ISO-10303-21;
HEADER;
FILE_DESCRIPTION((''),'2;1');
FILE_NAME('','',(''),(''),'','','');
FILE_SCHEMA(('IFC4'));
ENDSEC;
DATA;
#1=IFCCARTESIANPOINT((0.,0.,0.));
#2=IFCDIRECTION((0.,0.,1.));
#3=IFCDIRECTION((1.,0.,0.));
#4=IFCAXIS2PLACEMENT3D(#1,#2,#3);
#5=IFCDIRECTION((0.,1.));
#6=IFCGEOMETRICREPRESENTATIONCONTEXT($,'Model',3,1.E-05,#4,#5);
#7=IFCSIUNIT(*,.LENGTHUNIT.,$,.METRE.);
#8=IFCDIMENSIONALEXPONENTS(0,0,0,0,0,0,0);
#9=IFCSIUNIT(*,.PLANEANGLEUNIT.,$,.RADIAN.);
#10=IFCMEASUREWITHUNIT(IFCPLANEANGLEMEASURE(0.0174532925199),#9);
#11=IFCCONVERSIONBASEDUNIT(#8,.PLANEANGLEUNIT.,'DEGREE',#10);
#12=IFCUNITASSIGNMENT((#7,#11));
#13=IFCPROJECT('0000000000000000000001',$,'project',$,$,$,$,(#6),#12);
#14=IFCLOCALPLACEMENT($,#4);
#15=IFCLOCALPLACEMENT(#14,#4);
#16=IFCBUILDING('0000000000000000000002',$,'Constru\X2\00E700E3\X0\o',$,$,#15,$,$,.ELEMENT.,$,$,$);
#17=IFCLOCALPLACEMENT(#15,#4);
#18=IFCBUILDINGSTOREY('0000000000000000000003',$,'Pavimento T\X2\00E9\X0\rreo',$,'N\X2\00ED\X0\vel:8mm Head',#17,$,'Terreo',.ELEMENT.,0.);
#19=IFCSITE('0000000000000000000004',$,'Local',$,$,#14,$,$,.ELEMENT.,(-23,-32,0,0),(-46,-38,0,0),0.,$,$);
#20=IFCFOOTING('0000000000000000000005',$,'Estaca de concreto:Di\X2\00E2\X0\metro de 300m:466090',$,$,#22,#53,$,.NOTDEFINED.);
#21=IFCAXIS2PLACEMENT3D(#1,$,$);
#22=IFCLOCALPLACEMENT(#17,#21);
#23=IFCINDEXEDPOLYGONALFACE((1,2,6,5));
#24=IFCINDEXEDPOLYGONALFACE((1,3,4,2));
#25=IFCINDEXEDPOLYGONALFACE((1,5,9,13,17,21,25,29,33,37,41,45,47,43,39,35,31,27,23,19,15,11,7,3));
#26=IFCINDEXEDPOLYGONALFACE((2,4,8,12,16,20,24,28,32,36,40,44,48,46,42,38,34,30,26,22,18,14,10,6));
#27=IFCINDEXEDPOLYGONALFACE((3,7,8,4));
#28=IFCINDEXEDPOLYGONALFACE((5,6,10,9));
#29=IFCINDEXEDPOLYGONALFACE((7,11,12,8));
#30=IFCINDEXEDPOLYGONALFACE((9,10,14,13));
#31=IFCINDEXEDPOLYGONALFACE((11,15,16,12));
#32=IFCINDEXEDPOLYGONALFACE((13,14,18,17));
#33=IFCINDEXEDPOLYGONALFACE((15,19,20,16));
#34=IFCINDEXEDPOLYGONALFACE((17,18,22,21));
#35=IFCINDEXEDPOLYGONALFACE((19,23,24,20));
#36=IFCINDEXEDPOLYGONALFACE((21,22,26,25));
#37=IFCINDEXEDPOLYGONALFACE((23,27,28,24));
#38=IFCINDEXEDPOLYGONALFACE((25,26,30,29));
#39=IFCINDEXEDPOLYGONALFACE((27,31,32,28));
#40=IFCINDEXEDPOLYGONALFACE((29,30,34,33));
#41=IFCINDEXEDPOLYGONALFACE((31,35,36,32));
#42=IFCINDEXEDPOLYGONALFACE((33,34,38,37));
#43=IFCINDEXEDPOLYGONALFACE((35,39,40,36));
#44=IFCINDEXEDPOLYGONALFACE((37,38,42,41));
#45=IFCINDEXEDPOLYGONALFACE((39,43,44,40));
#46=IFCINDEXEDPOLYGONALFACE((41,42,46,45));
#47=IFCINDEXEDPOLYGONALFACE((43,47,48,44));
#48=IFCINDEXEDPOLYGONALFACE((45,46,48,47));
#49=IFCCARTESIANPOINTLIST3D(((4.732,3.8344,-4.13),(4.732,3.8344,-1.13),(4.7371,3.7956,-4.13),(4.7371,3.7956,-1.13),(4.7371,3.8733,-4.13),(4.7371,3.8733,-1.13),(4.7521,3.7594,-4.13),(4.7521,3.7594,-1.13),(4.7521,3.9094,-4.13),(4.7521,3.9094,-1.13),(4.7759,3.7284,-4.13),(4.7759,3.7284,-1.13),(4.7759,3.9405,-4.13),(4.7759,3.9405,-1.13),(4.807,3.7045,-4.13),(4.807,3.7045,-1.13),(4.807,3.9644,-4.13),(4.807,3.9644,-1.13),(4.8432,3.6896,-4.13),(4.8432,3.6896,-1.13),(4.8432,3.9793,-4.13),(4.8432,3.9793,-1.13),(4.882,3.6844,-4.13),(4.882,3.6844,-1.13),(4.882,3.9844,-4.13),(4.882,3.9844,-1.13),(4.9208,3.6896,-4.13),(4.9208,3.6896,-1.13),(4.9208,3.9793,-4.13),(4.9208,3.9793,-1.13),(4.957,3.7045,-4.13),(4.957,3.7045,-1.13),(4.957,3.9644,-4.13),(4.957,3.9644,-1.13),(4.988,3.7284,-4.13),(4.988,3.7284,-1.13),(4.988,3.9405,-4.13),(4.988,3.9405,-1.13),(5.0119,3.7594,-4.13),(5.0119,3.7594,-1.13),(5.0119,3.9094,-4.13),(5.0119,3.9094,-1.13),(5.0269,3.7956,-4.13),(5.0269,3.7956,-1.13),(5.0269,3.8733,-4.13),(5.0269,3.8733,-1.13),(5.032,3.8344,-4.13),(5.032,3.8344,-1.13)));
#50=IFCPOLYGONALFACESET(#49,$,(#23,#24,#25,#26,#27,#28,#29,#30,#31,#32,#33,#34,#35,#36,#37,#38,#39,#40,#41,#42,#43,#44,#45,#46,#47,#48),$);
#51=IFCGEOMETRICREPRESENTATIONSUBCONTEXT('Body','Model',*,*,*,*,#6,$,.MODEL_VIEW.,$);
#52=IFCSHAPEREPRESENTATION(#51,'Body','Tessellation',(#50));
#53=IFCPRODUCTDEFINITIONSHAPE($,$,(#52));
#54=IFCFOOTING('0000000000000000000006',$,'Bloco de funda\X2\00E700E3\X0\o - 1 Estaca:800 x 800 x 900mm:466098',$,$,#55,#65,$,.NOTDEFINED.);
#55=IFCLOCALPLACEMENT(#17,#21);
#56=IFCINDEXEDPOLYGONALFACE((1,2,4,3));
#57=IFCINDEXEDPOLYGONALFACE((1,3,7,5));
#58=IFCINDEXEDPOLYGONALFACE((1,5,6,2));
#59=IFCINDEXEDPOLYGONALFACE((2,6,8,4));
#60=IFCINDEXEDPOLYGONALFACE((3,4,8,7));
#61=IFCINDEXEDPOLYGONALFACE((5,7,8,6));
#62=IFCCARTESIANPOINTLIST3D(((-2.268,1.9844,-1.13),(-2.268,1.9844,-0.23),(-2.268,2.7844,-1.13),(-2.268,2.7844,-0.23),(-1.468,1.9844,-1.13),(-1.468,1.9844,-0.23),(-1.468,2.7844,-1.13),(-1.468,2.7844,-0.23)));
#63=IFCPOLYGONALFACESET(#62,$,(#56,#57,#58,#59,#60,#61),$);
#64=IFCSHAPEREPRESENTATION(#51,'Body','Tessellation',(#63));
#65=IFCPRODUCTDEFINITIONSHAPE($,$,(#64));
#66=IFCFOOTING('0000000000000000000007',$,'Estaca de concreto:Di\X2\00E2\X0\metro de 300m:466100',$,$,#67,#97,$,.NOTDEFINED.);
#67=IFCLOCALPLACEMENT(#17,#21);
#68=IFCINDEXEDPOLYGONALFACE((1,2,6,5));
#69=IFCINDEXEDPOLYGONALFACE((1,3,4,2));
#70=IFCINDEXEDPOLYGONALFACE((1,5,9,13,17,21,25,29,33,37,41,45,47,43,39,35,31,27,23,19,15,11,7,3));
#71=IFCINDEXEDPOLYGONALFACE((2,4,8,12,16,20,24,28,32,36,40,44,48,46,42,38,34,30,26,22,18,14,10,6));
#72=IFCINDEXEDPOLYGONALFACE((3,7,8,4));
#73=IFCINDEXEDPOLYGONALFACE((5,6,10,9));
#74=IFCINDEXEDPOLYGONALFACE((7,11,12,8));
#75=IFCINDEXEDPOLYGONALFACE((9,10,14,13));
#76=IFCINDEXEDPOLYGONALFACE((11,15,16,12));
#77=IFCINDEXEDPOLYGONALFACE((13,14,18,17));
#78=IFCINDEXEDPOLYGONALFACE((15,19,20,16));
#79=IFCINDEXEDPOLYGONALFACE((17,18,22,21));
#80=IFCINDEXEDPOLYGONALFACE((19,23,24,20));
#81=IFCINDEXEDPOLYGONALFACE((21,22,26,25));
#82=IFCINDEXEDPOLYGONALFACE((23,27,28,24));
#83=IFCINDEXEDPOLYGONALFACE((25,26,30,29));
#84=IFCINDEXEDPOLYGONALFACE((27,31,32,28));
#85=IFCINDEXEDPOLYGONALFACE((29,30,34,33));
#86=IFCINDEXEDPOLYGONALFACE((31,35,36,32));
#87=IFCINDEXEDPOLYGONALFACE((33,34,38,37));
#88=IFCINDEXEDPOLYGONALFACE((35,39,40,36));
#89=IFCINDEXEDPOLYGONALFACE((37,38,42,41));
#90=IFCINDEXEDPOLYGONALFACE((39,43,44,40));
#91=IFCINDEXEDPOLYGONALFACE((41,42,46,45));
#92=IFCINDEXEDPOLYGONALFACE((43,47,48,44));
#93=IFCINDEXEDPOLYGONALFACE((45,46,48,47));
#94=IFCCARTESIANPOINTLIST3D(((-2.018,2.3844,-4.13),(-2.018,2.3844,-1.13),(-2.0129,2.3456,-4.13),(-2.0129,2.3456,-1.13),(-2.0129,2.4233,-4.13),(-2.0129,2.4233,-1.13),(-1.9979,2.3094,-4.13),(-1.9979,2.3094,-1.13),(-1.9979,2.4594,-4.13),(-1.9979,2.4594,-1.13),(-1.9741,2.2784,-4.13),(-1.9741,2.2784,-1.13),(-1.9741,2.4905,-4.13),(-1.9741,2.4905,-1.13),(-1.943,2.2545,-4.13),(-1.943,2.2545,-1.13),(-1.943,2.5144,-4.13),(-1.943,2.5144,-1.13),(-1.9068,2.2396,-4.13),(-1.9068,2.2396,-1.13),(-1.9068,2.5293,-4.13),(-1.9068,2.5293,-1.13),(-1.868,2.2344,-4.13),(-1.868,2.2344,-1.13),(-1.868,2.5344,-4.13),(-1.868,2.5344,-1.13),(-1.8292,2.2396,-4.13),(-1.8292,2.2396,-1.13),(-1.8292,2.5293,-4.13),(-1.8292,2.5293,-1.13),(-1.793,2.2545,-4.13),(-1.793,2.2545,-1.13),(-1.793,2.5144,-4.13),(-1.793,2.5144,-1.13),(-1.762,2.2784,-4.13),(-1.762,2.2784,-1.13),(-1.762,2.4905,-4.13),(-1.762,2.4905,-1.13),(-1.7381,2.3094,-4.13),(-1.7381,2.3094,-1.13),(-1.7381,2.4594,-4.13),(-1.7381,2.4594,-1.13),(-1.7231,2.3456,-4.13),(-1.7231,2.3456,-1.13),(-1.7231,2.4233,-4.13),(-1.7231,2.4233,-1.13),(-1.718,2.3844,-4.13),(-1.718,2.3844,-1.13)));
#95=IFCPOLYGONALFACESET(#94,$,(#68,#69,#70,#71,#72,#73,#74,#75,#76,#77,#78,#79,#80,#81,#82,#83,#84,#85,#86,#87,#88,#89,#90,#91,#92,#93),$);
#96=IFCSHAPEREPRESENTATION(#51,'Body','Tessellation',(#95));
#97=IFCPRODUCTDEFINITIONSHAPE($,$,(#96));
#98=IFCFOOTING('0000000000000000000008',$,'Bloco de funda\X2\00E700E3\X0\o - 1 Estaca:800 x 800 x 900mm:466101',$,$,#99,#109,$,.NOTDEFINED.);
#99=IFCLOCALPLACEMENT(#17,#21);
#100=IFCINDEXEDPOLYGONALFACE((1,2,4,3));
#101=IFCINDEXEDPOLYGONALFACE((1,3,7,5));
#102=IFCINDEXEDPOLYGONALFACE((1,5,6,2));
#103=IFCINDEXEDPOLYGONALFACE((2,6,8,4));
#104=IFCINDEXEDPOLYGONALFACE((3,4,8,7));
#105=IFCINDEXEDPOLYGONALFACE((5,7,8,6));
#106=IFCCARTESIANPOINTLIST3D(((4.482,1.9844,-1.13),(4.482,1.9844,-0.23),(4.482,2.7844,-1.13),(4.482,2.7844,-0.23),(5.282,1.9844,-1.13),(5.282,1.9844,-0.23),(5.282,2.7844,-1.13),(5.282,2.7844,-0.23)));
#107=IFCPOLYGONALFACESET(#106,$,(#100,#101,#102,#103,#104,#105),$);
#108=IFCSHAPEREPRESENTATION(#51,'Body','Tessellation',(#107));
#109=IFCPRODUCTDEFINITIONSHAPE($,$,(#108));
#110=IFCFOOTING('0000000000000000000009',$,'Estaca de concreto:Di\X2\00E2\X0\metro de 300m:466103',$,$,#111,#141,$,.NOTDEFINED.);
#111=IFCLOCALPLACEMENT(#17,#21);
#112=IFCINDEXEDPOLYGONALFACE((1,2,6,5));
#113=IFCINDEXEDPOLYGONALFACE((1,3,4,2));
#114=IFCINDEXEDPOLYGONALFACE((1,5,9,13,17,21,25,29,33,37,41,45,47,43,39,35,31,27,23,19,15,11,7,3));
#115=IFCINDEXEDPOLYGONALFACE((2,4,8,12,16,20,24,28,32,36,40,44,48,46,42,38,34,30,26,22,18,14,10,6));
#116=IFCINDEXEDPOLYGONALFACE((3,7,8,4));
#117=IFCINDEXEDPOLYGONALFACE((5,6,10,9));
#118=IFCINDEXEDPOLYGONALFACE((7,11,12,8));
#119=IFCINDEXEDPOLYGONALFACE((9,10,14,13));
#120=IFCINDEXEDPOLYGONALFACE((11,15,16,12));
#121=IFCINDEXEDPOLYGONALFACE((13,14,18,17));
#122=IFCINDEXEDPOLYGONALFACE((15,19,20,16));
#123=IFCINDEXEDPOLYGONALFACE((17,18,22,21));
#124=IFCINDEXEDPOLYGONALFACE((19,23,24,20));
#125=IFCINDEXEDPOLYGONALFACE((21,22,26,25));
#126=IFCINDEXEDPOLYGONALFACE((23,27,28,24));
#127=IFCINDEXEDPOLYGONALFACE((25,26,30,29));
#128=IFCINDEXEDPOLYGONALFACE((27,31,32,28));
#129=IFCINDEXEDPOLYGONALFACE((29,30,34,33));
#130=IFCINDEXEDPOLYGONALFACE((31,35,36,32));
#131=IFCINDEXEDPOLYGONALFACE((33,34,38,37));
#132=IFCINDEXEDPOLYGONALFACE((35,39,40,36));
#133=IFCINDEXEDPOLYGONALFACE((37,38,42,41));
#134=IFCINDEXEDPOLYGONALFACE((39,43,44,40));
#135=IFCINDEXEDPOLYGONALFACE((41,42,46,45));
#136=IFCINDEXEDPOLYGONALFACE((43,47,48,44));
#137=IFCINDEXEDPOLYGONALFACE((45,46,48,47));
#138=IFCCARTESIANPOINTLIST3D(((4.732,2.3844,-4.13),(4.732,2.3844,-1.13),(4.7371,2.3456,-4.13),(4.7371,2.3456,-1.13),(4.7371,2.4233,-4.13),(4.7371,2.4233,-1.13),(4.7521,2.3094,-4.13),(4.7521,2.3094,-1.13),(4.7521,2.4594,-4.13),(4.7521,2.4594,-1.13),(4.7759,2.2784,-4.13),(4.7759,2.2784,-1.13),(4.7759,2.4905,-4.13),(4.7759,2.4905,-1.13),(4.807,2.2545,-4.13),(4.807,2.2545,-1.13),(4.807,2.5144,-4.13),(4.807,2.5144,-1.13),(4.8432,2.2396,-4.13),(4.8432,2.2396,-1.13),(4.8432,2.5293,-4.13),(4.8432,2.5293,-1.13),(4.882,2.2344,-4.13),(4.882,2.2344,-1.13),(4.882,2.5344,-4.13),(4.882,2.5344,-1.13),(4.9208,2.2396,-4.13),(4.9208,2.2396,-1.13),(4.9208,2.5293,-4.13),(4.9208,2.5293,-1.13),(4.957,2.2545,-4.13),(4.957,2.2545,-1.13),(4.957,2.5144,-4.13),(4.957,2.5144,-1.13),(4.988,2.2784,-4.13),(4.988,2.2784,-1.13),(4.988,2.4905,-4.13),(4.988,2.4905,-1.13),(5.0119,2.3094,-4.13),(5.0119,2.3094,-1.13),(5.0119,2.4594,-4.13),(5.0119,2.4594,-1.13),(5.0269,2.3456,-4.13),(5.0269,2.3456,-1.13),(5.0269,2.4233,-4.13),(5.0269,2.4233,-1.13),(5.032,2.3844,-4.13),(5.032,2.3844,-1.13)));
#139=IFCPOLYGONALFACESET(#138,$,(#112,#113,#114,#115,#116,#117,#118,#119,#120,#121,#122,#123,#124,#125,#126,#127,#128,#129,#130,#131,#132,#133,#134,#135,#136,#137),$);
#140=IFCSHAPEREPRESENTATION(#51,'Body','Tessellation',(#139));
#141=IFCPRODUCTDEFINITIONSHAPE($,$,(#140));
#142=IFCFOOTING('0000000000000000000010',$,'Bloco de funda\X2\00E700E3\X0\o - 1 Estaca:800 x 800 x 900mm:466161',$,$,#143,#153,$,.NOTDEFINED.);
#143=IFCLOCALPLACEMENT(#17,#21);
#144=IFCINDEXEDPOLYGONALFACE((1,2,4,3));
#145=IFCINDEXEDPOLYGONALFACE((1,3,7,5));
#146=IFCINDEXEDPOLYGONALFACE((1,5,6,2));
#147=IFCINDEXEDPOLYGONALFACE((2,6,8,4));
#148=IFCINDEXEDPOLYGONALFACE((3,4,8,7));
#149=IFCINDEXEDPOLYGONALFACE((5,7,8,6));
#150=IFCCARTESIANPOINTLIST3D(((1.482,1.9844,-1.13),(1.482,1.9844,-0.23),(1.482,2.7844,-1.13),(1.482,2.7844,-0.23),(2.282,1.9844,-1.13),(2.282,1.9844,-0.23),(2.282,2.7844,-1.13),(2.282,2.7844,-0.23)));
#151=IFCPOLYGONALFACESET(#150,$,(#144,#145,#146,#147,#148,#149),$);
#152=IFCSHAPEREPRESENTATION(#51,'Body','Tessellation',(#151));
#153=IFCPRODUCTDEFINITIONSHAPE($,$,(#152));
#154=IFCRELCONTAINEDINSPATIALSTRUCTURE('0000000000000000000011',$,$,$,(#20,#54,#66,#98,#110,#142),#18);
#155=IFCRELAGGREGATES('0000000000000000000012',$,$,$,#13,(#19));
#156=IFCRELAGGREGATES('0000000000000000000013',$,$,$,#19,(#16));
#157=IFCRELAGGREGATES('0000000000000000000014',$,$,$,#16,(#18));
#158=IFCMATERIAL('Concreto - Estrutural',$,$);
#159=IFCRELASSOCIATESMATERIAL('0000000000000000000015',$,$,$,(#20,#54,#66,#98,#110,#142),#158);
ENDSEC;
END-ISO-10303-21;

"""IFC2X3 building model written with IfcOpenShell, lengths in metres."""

from ifc_helpers import new_model, entity, si_unit, converted_unit, point, direction, frame, frame_2d, origin_with_axes, place, context, subcontext, project, spatial, polyline, circle_curve, parameter, trimmed, segment, composite_curve, outline, extrude, material, element, save


model = new_model("IFC2X3")

# Units and contexts
model_context = context("Model", 3, precision=1e-05, world=origin_with_axes(), true_north=direction((0.0, 1.0)))
body_context = subcontext(model_context, "Body", "Model", "MODEL_VIEW")
ifc_project = project(units=[si_unit("LENGTHUNIT", "METRE"), converted_unit("PLANEANGLEUNIT", "DEGREE", entity("IfcPlaneAngleMeasure", 0.0174532925199), si_unit("PLANEANGLEUNIT", "RADIAN"), dimensions=[0, 0, 0, 0, 0, 0, 0])], contexts=[model_context])

# Site, building, storey
site_placement = place(None, origin_with_axes())
site = spatial("IfcSite", under=ifc_project, at=site_placement, Name="Local", CompositionType="ELEMENT", RefLatitude=(-23, -32, 0, 0), RefLongitude=(-46, -38, 0, 0), RefElevation=0.0)
building_placement = place(site_placement, origin_with_axes())
building = spatial("IfcBuilding", under=site, at=building_placement, Name="Construção", CompositionType="ELEMENT")
storey_placement = place(building_placement, origin_with_axes())
storey = spatial("IfcBuildingStorey", under=building, at=storey_placement, Name="Pavimento Térreo", ObjectType="Nível:8mm Head", LongName="Terreo", CompositionType="ELEMENT", Elevation=0.0)

# Footings
ifc_material = material(Name="Concreto - Estrutural")
footing_1_placement = place(storey_placement, frame((5.032, 3.8344, -1.13), z_axis=(0.0, 0.0, 1.0), x_axis=(1.0, 0.0, 0.0)))
element("IfcFooting", 1, at=footing_1_placement, inside=storey, material=ifc_material, Name="Estaca de concreto:Diâmetro de 300m:466090", PredefinedType="NOTDEFINED", context=body_context, shape_type="SweptSolid", body=[
    extrude(outline(composite_curve([segment(trimmed(circle_curve(frame_2d((-0.15, 0.0), x_axis=(1.0, 0.0)), 0.15), [point((0.0, 0.0)), parameter(0.0)], [point((-0.15, 0.15)), parameter(90.0)], True, "CARTESIAN"), True, "CONTINUOUS"), segment(trimmed(circle_curve(frame_2d((-0.15, 0.0), x_axis=(0.0, 1.0)), 0.15), [point((-0.15, 0.15)), parameter(0.0)], [point((-0.3, 0.0)), parameter(90.0)], True, "CARTESIAN"), True, "CONTINUOUS"), segment(trimmed(circle_curve(frame_2d((-0.15, 0.0), x_axis=(-1.0, 0.0)), 0.15), [point((-0.3, 0.0)), parameter(0.0)], [point((-0.15, -0.15)), parameter(90.0)], True, "CARTESIAN"), True, "CONTINUOUS"), segment(trimmed(circle_curve(frame_2d((-0.15, 0.0), x_axis=(0.0, -1.0)), 0.15), [point((-0.15, -0.15)), parameter(0.0)], [point((0.0, 0.0)), parameter(90.0)], True, "CARTESIAN"), True, "CONTINUOUS")], self_intersect=False)), frame((0.0, 0.0, -3.0), z_axis=(0.0, 0.0, 1.0), x_axis=(1.0, 0.0, 0.0)), (0.0, 0.0, 1.0), 3.0),
])
footing_2_placement = place(storey_placement, frame((-2.268, 2.7844, -0.23), z_axis=(0.0, 0.0, 1.0), x_axis=(1.0, 0.0, 0.0)))
element("IfcFooting", 2, at=footing_2_placement, inside=storey, material=ifc_material, Name="Bloco de fundação - 1 Estaca:800 x 800 x 900mm:466098", PredefinedType="NOTDEFINED", context=body_context, shape_type="SweptSolid", body=[
    extrude(outline(polyline([(0.0, 0.0), (0.0, -0.8), (0.8, -0.8), (0.8, 0.0), (0.0, 0.0)])), frame((0.0, 0.0, -0.9), z_axis=(0.0, 0.0, 1.0), x_axis=(1.0, 0.0, 0.0)), (0.0, 0.0, 1.0), 0.9),
])
footing_3_placement = place(storey_placement, frame((-1.718, 2.3844, -1.13), z_axis=(0.0, 0.0, 1.0), x_axis=(1.0, 0.0, 0.0)))
element("IfcFooting", 3, at=footing_3_placement, inside=storey, material=ifc_material, Name="Estaca de concreto:Diâmetro de 300m:466100", PredefinedType="NOTDEFINED", context=body_context, shape_type="SweptSolid", body=[
    extrude(outline(composite_curve([segment(trimmed(circle_curve(frame_2d((-0.15, 0.0), x_axis=(1.0, 0.0)), 0.15), [point((0.0, 0.0)), parameter(0.0)], [point((-0.15, 0.15)), parameter(90.0)], True, "CARTESIAN"), True, "CONTINUOUS"), segment(trimmed(circle_curve(frame_2d((-0.15, 0.0), x_axis=(0.0, 1.0)), 0.15), [point((-0.15, 0.15)), parameter(0.0)], [point((-0.3, 0.0)), parameter(90.0)], True, "CARTESIAN"), True, "CONTINUOUS"), segment(trimmed(circle_curve(frame_2d((-0.15, 0.0), x_axis=(-1.0, 0.0)), 0.15), [point((-0.3, 0.0)), parameter(0.0)], [point((-0.15, -0.15)), parameter(90.0)], True, "CARTESIAN"), True, "CONTINUOUS"), segment(trimmed(circle_curve(frame_2d((-0.15, 0.0), x_axis=(0.0, -1.0)), 0.15), [point((-0.15, -0.15)), parameter(0.0)], [point((0.0, 0.0)), parameter(90.0)], True, "CARTESIAN"), True, "CONTINUOUS")], self_intersect=False)), frame((0.0, 0.0, -3.0), z_axis=(0.0, 0.0, 1.0), x_axis=(1.0, 0.0, 0.0)), (0.0, 0.0, 1.0), 3.0),
])
footing_4_placement = place(storey_placement, frame((4.482, 2.7844, -0.23), z_axis=(0.0, 0.0, 1.0), x_axis=(1.0, 0.0, 0.0)))
element("IfcFooting", 4, at=footing_4_placement, inside=storey, material=ifc_material, Name="Bloco de fundação - 1 Estaca:800 x 800 x 900mm:466101", PredefinedType="NOTDEFINED", context=body_context, shape_type="SweptSolid", body=[
    extrude(outline(polyline([(0.0, 0.0), (0.0, -0.8), (0.8, -0.8), (0.8, 0.0), (0.0, 0.0)])), frame((0.0, 0.0, -0.9), z_axis=(0.0, 0.0, 1.0), x_axis=(1.0, 0.0, 0.0)), (0.0, 0.0, 1.0), 0.9),
])
footing_5_placement = place(storey_placement, frame((5.032, 2.3844, -1.13), z_axis=(0.0, 0.0, 1.0), x_axis=(1.0, 0.0, 0.0)))
element("IfcFooting", 5, at=footing_5_placement, inside=storey, material=ifc_material, Name="Estaca de concreto:Diâmetro de 300m:466103", PredefinedType="NOTDEFINED", context=body_context, shape_type="SweptSolid", body=[
    extrude(outline(composite_curve([segment(trimmed(circle_curve(frame_2d((-0.15, 0.0), x_axis=(1.0, 0.0)), 0.15), [point((0.0, 0.0)), parameter(0.0)], [point((-0.15, 0.15)), parameter(90.0)], True, "CARTESIAN"), True, "CONTINUOUS"), segment(trimmed(circle_curve(frame_2d((-0.15, 0.0), x_axis=(0.0, 1.0)), 0.15), [point((-0.15, 0.15)), parameter(0.0)], [point((-0.3, 0.0)), parameter(90.0)], True, "CARTESIAN"), True, "CONTINUOUS"), segment(trimmed(circle_curve(frame_2d((-0.15, 0.0), x_axis=(-1.0, 0.0)), 0.15), [point((-0.3, 0.0)), parameter(0.0)], [point((-0.15, -0.15)), parameter(90.0)], True, "CARTESIAN"), True, "CONTINUOUS"), segment(trimmed(circle_curve(frame_2d((-0.15, 0.0), x_axis=(0.0, -1.0)), 0.15), [point((-0.15, -0.15)), parameter(0.0)], [point((0.0, 0.0)), parameter(90.0)], True, "CARTESIAN"), True, "CONTINUOUS")], self_intersect=False)), frame((0.0, 0.0, -3.0), z_axis=(0.0, 0.0, 1.0), x_axis=(1.0, 0.0, 0.0)), (0.0, 0.0, 1.0), 3.0),
])
footing_6_placement = place(storey_placement, frame((1.482, 2.7844, -0.23), z_axis=(0.0, 0.0, 1.0), x_axis=(1.0, 0.0, 0.0)))
element("IfcFooting", 6, at=footing_6_placement, inside=storey, material=ifc_material, Name="Bloco de fundação - 1 Estaca:800 x 800 x 900mm:466161", PredefinedType="NOTDEFINED", context=body_context, shape_type="SweptSolid", body=[
    extrude(outline(polyline([(0.0, 0.0), (0.0, -0.8), (0.8, -0.8), (0.8, 0.0), (0.0, 0.0)])), frame((0.0, 0.0, -0.9), z_axis=(0.0, 0.0, 1.0), x_axis=(1.0, 0.0, 0.0)), (0.0, 0.0, 1.0), 0.9),
])

save(model, "model.ifc")
